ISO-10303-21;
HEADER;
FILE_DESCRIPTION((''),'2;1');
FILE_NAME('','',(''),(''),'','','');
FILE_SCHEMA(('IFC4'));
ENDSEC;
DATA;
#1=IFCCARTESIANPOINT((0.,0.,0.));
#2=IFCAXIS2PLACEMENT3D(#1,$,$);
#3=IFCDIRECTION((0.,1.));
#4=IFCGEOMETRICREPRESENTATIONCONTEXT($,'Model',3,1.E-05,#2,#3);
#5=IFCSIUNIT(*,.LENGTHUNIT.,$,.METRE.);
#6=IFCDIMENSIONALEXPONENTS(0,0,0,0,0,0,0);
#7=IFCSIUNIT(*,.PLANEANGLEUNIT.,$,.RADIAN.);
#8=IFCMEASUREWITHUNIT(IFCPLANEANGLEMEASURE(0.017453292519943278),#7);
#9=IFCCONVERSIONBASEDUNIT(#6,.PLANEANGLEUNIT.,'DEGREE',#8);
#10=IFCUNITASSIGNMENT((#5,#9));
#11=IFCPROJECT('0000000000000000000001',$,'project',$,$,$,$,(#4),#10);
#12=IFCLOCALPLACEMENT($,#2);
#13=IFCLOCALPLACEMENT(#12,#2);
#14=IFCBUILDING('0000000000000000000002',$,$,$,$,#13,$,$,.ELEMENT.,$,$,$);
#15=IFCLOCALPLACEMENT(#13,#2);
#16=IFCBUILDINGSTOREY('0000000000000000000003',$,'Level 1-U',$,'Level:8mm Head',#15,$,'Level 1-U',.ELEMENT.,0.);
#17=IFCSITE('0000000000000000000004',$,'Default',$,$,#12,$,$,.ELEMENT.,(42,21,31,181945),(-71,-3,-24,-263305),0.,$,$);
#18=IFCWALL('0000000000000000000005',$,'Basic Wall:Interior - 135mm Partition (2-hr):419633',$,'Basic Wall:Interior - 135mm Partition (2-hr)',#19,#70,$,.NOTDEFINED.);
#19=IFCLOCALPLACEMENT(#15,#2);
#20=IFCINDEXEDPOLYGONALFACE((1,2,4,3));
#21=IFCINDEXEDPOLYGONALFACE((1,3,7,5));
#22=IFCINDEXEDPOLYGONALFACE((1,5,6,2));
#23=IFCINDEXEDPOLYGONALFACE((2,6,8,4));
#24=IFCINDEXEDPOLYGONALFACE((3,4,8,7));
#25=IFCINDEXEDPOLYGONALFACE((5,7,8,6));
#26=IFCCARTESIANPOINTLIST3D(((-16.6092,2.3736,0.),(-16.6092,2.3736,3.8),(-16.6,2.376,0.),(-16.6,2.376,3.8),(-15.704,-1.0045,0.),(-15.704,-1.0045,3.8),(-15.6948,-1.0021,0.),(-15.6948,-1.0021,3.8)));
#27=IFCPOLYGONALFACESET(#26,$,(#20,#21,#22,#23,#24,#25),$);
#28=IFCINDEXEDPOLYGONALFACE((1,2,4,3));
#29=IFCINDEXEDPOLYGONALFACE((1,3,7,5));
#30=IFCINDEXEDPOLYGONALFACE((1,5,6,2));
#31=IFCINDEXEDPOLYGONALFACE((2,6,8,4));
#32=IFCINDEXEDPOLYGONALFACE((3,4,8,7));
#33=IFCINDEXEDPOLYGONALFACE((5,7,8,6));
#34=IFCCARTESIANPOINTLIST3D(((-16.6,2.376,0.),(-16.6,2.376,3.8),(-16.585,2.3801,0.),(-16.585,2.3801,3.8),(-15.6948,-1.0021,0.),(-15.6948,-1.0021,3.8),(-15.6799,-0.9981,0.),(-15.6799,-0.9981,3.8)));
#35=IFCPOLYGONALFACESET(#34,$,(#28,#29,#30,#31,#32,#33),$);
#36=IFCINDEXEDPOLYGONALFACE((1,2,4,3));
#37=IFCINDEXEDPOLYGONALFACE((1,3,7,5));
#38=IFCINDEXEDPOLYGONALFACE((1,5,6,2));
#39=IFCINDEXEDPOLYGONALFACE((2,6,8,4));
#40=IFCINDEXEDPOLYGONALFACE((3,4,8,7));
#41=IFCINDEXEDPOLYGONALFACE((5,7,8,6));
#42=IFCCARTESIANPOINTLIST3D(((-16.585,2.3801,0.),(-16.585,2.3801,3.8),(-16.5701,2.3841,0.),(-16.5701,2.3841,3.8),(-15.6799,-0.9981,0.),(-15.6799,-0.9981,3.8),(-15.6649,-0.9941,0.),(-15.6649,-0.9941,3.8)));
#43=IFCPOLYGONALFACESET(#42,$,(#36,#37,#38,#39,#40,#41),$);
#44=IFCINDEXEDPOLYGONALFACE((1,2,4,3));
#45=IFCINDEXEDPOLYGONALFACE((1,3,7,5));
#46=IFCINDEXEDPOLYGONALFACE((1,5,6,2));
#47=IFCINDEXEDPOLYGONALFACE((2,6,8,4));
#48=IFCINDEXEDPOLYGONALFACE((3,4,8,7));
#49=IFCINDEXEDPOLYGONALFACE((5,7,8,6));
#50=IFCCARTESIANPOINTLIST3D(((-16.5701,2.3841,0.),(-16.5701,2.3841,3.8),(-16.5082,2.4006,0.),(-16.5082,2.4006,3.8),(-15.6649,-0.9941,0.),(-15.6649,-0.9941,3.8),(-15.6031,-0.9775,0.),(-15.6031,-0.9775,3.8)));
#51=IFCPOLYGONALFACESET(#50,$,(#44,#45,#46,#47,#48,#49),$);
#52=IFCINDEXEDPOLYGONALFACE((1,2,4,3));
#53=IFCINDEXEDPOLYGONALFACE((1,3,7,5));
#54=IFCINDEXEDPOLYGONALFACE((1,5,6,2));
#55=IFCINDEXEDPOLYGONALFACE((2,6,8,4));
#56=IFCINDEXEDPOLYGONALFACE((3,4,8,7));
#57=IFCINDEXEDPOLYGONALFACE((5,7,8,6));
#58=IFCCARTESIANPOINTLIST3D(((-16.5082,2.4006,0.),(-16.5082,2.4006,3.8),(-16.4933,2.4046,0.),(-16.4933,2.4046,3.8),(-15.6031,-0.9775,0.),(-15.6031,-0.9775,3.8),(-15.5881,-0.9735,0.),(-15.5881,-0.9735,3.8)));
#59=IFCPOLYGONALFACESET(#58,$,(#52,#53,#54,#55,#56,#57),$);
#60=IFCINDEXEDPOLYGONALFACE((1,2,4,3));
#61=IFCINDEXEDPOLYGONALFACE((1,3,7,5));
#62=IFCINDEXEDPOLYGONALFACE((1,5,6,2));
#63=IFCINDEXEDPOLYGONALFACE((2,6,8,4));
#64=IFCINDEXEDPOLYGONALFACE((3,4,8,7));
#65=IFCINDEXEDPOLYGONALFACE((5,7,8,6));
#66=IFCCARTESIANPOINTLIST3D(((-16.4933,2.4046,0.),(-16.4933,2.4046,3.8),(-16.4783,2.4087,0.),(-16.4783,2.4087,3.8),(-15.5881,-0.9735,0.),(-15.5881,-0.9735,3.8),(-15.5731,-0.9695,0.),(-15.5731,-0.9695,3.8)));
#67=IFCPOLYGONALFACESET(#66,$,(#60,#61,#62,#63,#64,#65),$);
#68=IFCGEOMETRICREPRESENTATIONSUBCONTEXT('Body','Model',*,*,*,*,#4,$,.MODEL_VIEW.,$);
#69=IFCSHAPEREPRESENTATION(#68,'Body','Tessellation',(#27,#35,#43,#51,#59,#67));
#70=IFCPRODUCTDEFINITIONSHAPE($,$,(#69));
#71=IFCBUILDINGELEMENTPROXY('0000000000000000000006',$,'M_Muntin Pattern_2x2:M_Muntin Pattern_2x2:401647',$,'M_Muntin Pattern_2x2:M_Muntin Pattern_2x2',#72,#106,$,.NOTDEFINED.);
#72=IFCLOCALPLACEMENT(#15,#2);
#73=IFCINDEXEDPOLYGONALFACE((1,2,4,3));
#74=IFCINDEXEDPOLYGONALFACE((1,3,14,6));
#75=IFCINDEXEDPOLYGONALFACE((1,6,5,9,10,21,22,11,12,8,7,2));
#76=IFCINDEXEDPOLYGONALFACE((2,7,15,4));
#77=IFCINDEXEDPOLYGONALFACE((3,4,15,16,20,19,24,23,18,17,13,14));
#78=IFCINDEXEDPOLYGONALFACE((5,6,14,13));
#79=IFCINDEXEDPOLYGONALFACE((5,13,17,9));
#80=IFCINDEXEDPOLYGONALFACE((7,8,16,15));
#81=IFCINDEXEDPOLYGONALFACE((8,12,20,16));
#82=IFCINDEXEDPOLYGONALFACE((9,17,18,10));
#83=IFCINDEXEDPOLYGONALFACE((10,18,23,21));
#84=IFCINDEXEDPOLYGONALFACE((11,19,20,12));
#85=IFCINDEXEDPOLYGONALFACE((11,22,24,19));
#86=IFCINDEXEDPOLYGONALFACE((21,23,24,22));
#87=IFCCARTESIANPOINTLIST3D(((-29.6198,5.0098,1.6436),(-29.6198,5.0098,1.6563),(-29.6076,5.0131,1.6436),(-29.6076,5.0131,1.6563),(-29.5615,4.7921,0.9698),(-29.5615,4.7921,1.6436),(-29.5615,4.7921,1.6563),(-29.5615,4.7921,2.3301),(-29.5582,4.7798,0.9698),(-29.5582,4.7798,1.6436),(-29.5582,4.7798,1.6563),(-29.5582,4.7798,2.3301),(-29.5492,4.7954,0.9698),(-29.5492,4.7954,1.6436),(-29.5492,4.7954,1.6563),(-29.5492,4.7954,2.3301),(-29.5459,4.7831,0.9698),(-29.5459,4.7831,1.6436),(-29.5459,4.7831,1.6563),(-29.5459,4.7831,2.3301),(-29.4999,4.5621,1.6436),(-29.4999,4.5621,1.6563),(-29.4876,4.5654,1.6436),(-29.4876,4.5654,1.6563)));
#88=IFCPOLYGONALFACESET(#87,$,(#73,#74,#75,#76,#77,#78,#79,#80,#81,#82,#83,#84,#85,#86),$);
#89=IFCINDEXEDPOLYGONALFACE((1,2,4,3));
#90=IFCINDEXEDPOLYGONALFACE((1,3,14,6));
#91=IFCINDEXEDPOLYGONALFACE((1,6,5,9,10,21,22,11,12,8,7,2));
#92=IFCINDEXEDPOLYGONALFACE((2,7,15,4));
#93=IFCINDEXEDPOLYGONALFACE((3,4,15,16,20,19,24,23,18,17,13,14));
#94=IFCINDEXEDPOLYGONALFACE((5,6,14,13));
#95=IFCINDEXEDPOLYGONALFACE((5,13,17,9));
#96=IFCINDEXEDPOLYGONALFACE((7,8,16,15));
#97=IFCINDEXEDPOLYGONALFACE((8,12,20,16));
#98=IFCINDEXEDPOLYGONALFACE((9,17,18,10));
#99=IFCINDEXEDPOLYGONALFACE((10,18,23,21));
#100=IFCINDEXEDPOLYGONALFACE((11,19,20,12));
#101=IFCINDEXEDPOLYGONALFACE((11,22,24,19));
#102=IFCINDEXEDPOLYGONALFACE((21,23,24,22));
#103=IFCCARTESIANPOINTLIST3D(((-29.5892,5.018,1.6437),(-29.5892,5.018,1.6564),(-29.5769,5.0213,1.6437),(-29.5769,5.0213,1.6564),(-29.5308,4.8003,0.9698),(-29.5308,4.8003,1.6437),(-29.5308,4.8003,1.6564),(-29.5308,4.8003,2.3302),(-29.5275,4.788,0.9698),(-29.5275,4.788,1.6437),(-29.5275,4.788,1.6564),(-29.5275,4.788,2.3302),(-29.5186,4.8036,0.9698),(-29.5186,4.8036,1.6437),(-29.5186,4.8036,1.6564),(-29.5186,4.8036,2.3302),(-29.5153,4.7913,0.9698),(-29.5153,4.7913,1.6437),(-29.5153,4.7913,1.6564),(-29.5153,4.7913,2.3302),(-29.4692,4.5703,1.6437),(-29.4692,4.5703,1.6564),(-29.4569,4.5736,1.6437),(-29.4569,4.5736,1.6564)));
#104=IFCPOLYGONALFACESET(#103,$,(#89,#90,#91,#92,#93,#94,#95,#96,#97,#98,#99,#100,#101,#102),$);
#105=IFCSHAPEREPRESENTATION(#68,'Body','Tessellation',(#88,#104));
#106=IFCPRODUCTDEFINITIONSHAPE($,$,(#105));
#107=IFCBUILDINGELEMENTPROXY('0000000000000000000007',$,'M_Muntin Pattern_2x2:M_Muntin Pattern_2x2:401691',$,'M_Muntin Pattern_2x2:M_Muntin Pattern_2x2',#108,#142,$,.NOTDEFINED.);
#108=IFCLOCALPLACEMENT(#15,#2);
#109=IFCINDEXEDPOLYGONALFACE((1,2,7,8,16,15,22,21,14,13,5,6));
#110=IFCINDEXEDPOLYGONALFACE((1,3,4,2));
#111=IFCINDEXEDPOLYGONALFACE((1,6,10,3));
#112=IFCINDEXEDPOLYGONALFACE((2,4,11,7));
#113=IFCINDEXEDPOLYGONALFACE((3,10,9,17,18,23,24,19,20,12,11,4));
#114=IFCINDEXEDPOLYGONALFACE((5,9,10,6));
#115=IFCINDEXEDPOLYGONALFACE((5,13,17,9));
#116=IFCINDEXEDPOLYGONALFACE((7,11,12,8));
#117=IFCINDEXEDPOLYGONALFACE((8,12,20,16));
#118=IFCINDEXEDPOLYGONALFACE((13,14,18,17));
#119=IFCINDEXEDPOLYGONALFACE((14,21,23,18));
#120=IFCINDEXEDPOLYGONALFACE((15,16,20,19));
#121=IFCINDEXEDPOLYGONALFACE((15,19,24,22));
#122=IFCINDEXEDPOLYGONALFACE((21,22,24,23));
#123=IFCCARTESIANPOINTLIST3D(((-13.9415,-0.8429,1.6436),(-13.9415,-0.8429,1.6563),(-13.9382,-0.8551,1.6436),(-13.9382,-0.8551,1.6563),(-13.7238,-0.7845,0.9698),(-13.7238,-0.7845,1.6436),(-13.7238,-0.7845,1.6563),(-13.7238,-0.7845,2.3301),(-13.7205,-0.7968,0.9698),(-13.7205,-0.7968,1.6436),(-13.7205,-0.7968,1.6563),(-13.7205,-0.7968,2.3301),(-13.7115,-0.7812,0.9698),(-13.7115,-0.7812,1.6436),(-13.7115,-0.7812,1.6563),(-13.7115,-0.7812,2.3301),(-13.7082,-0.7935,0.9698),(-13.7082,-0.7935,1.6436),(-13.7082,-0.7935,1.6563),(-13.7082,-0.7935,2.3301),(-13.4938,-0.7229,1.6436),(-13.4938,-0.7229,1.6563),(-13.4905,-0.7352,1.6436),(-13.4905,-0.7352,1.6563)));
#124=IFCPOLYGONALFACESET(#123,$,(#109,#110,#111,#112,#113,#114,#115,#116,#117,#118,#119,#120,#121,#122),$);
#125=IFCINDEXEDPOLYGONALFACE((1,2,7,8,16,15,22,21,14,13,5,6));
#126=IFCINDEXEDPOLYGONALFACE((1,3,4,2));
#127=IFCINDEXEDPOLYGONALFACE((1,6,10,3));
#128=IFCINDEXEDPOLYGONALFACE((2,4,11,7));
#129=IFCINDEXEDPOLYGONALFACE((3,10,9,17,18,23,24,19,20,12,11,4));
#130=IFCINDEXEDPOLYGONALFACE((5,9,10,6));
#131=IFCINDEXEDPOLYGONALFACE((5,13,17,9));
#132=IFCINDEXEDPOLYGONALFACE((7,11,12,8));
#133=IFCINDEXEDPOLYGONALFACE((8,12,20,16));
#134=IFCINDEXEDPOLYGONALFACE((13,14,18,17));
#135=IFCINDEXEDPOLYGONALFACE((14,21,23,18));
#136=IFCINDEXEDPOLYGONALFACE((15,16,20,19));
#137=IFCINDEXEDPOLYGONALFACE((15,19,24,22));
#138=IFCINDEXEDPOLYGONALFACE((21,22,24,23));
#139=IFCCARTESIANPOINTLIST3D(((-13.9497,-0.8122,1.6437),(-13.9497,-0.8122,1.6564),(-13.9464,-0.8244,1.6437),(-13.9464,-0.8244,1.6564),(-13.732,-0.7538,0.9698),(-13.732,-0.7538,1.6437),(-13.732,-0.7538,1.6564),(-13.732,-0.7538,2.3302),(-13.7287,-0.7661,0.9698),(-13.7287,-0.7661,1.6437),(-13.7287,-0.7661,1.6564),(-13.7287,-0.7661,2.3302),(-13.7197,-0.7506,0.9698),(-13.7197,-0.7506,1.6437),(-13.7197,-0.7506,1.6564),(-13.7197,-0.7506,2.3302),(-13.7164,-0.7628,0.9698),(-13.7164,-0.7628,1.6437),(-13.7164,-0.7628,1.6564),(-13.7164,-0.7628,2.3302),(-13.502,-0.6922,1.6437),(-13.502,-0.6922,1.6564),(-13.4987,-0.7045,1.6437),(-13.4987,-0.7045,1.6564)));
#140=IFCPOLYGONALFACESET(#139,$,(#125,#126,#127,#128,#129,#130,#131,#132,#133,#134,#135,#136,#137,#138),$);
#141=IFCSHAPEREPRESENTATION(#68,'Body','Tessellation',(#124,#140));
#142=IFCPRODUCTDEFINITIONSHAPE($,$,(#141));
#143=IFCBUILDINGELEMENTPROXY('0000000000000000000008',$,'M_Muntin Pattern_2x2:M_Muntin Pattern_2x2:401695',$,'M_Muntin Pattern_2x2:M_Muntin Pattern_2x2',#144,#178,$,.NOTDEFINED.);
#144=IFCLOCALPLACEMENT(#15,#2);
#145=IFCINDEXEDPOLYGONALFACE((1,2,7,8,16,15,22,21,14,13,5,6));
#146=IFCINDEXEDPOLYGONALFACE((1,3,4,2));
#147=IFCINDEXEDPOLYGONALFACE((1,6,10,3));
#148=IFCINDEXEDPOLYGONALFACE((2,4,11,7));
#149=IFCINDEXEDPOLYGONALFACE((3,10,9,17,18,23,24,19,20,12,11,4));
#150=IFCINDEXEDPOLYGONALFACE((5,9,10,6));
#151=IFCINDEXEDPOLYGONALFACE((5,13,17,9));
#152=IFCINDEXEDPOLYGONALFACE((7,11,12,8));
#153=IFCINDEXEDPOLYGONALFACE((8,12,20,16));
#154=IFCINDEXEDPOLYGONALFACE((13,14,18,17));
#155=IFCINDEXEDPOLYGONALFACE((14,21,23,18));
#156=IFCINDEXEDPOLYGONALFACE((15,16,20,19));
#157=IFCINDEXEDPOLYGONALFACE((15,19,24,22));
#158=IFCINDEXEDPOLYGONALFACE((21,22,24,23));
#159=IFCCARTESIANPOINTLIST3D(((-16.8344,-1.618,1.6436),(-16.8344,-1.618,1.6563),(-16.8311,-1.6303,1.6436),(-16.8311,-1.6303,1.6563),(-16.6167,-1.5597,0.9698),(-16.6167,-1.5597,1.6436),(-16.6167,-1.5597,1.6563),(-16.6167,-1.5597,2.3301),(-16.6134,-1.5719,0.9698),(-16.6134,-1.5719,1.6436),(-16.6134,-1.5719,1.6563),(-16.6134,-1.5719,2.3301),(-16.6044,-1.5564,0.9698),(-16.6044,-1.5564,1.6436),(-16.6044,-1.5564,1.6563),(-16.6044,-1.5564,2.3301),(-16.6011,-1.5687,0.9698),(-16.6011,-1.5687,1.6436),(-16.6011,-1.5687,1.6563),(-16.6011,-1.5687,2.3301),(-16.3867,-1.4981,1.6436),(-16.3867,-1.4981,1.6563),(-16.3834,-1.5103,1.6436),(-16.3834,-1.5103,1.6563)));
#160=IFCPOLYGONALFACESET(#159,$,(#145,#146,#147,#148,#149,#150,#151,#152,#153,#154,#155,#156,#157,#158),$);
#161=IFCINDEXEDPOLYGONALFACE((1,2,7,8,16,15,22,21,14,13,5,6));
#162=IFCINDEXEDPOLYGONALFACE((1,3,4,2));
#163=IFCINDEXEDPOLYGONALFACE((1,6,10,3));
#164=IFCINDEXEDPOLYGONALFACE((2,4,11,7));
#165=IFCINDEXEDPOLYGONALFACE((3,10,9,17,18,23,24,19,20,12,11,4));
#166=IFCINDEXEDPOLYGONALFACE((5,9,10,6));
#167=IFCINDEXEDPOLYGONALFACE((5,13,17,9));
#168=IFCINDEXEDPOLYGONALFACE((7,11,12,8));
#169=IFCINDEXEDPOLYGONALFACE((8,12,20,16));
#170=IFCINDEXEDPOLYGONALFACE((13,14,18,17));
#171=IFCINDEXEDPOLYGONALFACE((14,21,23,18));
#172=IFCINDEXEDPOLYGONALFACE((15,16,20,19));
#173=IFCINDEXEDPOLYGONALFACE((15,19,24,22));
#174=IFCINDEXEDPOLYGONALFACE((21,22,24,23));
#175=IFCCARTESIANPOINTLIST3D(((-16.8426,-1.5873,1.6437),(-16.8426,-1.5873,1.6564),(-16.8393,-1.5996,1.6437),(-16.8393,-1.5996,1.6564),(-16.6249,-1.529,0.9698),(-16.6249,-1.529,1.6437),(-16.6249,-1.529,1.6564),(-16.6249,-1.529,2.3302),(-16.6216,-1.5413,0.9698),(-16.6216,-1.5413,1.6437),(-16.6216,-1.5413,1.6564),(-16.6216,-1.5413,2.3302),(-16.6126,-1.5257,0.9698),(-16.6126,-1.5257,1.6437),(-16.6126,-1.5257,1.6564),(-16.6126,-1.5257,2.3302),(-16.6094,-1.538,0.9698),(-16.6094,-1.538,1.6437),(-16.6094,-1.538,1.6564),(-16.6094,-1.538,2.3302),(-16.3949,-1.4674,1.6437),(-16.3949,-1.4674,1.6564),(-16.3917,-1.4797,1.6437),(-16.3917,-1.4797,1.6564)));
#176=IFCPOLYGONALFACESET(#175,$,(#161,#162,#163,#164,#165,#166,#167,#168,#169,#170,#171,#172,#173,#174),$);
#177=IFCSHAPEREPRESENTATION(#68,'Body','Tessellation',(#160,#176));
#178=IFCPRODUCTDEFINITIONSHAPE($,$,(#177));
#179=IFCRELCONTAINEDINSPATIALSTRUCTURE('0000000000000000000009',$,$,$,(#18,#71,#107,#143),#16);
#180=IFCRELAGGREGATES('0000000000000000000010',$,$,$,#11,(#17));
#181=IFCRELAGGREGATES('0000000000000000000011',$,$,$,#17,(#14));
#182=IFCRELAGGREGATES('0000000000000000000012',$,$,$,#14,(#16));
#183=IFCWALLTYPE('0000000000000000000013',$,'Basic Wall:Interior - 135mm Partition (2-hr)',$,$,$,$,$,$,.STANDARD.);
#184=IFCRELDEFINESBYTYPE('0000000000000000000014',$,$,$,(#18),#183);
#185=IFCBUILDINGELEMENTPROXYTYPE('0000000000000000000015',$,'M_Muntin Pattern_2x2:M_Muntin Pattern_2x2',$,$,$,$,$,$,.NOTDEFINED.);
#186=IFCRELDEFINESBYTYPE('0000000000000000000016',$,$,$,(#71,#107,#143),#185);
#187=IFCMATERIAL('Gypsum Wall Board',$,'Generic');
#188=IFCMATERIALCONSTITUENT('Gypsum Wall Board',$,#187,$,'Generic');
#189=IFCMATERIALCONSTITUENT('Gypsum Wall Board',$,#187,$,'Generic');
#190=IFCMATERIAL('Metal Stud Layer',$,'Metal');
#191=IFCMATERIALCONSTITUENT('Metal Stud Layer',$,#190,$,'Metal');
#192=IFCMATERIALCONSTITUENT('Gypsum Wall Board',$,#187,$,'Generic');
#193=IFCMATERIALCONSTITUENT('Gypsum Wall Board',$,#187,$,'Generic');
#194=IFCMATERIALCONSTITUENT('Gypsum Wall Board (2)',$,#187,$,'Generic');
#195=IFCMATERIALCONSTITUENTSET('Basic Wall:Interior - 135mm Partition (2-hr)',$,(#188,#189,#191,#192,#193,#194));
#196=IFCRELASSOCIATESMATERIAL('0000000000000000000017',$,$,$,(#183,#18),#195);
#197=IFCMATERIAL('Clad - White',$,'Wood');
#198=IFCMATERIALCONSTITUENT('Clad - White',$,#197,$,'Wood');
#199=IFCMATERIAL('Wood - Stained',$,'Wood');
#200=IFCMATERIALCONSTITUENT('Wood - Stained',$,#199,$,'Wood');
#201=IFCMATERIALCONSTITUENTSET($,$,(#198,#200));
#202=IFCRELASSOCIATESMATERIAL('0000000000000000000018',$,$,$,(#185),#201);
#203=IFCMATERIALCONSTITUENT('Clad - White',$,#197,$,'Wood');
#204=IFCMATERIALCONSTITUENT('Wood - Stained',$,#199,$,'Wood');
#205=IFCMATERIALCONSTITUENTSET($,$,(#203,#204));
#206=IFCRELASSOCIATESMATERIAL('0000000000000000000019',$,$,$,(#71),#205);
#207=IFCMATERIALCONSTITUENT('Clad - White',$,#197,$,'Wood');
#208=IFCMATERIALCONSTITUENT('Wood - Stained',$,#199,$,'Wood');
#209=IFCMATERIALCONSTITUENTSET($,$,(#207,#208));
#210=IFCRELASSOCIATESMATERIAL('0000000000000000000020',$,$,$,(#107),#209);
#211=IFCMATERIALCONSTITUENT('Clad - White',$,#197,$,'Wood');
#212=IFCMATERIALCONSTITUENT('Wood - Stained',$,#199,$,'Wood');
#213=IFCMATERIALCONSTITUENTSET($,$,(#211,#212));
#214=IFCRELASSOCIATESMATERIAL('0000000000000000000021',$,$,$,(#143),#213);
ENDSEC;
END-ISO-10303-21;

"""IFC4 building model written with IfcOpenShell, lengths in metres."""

from ifc_helpers import new_model, entity, si_unit, converted_unit, direction, frame, origin, place, context, subcontext, project, spatial, indexed_curve, outline, extrude, source, transform, mapped, material, constituent, constituent_set, type_object, type_shapes, element, save


model = new_model("IFC4")

# Units and contexts
model_context = context("Model", 3, precision=1e-05, world=origin(), true_north=direction((0.0, 1.0)))
body_context = subcontext(model_context, "Body", "Model", "MODEL_VIEW")
ifc_project = project(units=[si_unit("LENGTHUNIT", "METRE"), converted_unit("PLANEANGLEUNIT", "DEGREE", entity("IfcPlaneAngleMeasure", 0.017453292519943278), si_unit("PLANEANGLEUNIT", "RADIAN"), dimensions=[0, 0, 0, 0, 0, 0, 0])], contexts=[model_context])

# Site, building, storey
site_placement = place(None, origin())
site = spatial("IfcSite", under=ifc_project, at=site_placement, Name="Default", CompositionType="ELEMENT", RefLatitude=(42, 21, 31, 181945), RefLongitude=(-71, -3, -24, -263305), RefElevation=0.0)
building_placement = place(site_placement, origin())
building = spatial("IfcBuilding", under=site, at=building_placement, CompositionType="ELEMENT")
storey_placement = place(building_placement, origin())
storey = spatial("IfcBuildingStorey", under=building, at=storey_placement, Name="Level 1-U", ObjectType="Level:8mm Head", LongName="Level 1-U", CompositionType="ELEMENT", Elevation=0.0)

# Shared definitions
ifc_material_1 = material(Name="Gypsum Wall Board", Category="Generic")
ifc_constituent_1 = constituent(ifc_material_1, Name="Gypsum Wall Board", Category="Generic")
ifc_constituent_2 = constituent(ifc_material_1, Name="Gypsum Wall Board", Category="Generic")
ifc_material_2 = material(Name="Metal Stud Layer", Category="Metal")
ifc_constituent_3 = constituent(ifc_material_2, Name="Metal Stud Layer", Category="Metal")
ifc_constituent_4 = constituent(ifc_material_1, Name="Gypsum Wall Board", Category="Generic")
ifc_constituent_5 = constituent(ifc_material_1, Name="Gypsum Wall Board", Category="Generic")
ifc_constituent_6 = constituent(ifc_material_1, Name="Gypsum Wall Board (2)", Category="Generic")
ifc_constituent_set_1 = constituent_set(constituents=[ifc_constituent_1, ifc_constituent_2, ifc_constituent_3, ifc_constituent_4, ifc_constituent_5, ifc_constituent_6], Name="Basic Wall:Interior - 135mm Partition (2-hr)")
wall_type_1 = type_object("IfcWallType", Name="Basic Wall:Interior - 135mm Partition (2-hr)", PredefinedType="STANDARD", material=ifc_constituent_set_1)

# Wall
wall_1_placement = place(storey_placement, frame((-16.5437, 2.3911, 0.0), z_axis=(0.0, 0.0, 1.0), x_axis=(0.258819, -0.965926, 0.0)))
element("IfcWall", 1, at=wall_1_placement, inside=storey, type_object=wall_type_1, material=ifc_constituent_set_1, Name="Basic Wall:Interior - 135mm Partition (2-hr):419633", ObjectType="Basic Wall:Interior - 135mm Partition (2-hr)", PredefinedType="NOTDEFINED", context=body_context, shape_type="SweptSolid", body=[
    extrude(outline(indexed_curve([(-0.0047, -1.7487), (0.0048, -1.7487), (0.0047, 1.7487), (-0.0048, 1.7487), (-0.0047, -1.7487)], self_intersect=False)), frame((1.7487, -0.063, 0.0), z_axis=(0.0, 0.0, 1.0), x_axis=(0.0, 1.0, 0.0)), (0.0, 0.0, 1.0), 3.8),
    extrude(outline(indexed_curve([(-1.7487, -0.0078), (1.7487, -0.0077), (1.7487, 0.0078), (-1.7487, 0.0077), (-1.7487, -0.0078)], self_intersect=False)), frame((1.7487, -0.0505, 0.0)), (0.0, 0.0, 1.0), 3.8),
    extrude(outline(indexed_curve([(-1.7487, -0.0078), (1.7487, -0.0077), (1.7487, 0.0078), (-1.7487, 0.0077), (-1.7487, -0.0078)], self_intersect=False)), frame((1.7487, -0.035, 0.0)), (0.0, 0.0, 1.0), 3.8),
    extrude(outline(indexed_curve([(-1.7487, -0.032), (1.7487, -0.032), (1.7487, 0.032), (-1.7487, 0.032), (-1.7487, -0.032)], self_intersect=False)), frame((1.7487, 0.0047, 0.0)), (0.0, 0.0, 1.0), 3.8),
    extrude(outline(indexed_curve([(-1.7487, -0.0078), (1.7487, -0.0077), (1.7487, 0.0078), (-1.7487, 0.0077), (-1.7487, -0.0078)], self_intersect=False)), frame((1.7487, 0.0445, 0.0)), (0.0, 0.0, 1.0), 3.8),
    extrude(outline(indexed_curve([(-0.0077, -1.7487), (0.0078, -1.7487), (0.0077, 1.7487), (-0.0078, 1.7487), (-0.0077, -1.7487)], self_intersect=False)), frame((1.7487, 0.06, 0.0), z_axis=(0.0, 0.0, 1.0), x_axis=(0.0, -1.0, 0.0)), (0.0, 0.0, 1.0), 3.8),
])

# Building element proxies
ifc_material_3 = material(Name="Clad - White", Category="Wood")
ifc_constituent_7 = constituent(ifc_material_3, Name="Clad - White", Category="Wood")
ifc_material_4 = material(Name="Wood - Stained", Category="Wood")
ifc_constituent_8 = constituent(ifc_material_4, Name="Wood - Stained", Category="Wood")
ifc_constituent_set_2 = constituent_set(constituents=[ifc_constituent_7, ifc_constituent_8])
ifc_constituent_9 = constituent(ifc_material_3, Name="Clad - White", Category="Wood")
ifc_constituent_10 = constituent(ifc_material_4, Name="Wood - Stained", Category="Wood")
ifc_constituent_set_3 = constituent_set(constituents=[ifc_constituent_9, ifc_constituent_10])
building_element_proxy_type_1 = type_object("IfcBuildingElementProxyType", Name="M_Muntin Pattern_2x2:M_Muntin Pattern_2x2", PredefinedType="NOTDEFINED", material=ifc_constituent_set_3)
shared_shape_1 = source(origin(), body_context, "Body", "SweptSolid", [
    extrude(outline(indexed_curve([(0.0064, -0.0064), (0.6801, -0.0064), (0.6801, 0.0063), (0.0064, 0.0063), (0.0064, 0.2317), (-0.0063, 0.2317), (-0.0063, 0.0063), (-0.6802, 0.0063), (-0.6802, -0.0064), (-0.0063, -0.0064), (-0.0063, -0.2317), (0.0064, -0.2317), (0.0064, -0.0064)], self_intersect=False)), frame((0.0, 0.0095, 0.6801), z_axis=(0.0, 1.0, 0.0), x_axis=(0.0, 0.0, 1.0)), (0.0, 0.0, 1.0), 0.0127),
    extrude(outline(indexed_curve([(0.0064, -0.0064), (0.6802, -0.0064), (0.6802, 0.0063), (0.0064, 0.0063), (0.0064, 0.2317), (-0.0063, 0.2317), (-0.0063, 0.0063), (-0.6802, 0.0063), (-0.6802, -0.0064), (-0.0063, -0.0064), (-0.0063, -0.2317), (0.0064, -0.2317), (0.0064, -0.0064)], self_intersect=False)), frame((0.0, -0.0222, 0.6802), z_axis=(0.0, 1.0, 0.0), x_axis=(0.0, 0.0, 1.0)), (0.0, 0.0, 1.0), 0.0127),
])
type_shapes(building_element_proxy_type_1, [shared_shape_1])
proxy_1_placement = place(storey_placement, frame((-29.5384, 4.7917, 0.9698), z_axis=(0.0, 0.0, 1.0), x_axis=(-0.258819, 0.965926, 0.0)))
element("IfcBuildingElementProxy", 2, at=proxy_1_placement, inside=storey, type_object=building_element_proxy_type_1, material=ifc_constituent_set_2, Name="M_Muntin Pattern_2x2:M_Muntin Pattern_2x2:401647", ObjectType="M_Muntin Pattern_2x2:M_Muntin Pattern_2x2", PredefinedType="NOTDEFINED", context=body_context, shape_type="MappedRepresentation", body=[
    mapped(shared_shape_1, transform((0.0, 0.0, 0.0), scale=1.0)),
])
ifc_constituent_11 = constituent(ifc_material_3, Name="Clad - White", Category="Wood")
ifc_constituent_12 = constituent(ifc_material_4, Name="Wood - Stained", Category="Wood")
ifc_constituent_set_4 = constituent_set(constituents=[ifc_constituent_11, ifc_constituent_12])
proxy_2_placement = place(storey_placement, frame((-13.7201, -0.7737, 0.9698), z_axis=(0.0, 0.0, 1.0), x_axis=(-0.965926, -0.258819, 0.0)))
element("IfcBuildingElementProxy", 3, at=proxy_2_placement, inside=storey, type_object=building_element_proxy_type_1, material=ifc_constituent_set_4, Name="M_Muntin Pattern_2x2:M_Muntin Pattern_2x2:401691", ObjectType="M_Muntin Pattern_2x2:M_Muntin Pattern_2x2", PredefinedType="NOTDEFINED", context=body_context, shape_type="MappedRepresentation", body=[
    mapped(shared_shape_1, transform((0.0, 0.0, 0.0), scale=1.0)),
])
ifc_constituent_13 = constituent(ifc_material_3, Name="Clad - White", Category="Wood")
ifc_constituent_14 = constituent(ifc_material_4, Name="Wood - Stained", Category="Wood")
ifc_constituent_set_5 = constituent_set(constituents=[ifc_constituent_13, ifc_constituent_14])
proxy_3_placement = place(storey_placement, frame((-16.613, -1.5488, 0.9698), z_axis=(0.0, 0.0, 1.0), x_axis=(-0.965926, -0.258819, 0.0)))
element("IfcBuildingElementProxy", 4, at=proxy_3_placement, inside=storey, type_object=building_element_proxy_type_1, material=ifc_constituent_set_5, Name="M_Muntin Pattern_2x2:M_Muntin Pattern_2x2:401695", ObjectType="M_Muntin Pattern_2x2:M_Muntin Pattern_2x2", PredefinedType="NOTDEFINED", context=body_context, shape_type="MappedRepresentation", body=[
    mapped(shared_shape_1, transform((0.0, 0.0, 0.0), scale=1.0)),
])

save(model, "model.ifc")
